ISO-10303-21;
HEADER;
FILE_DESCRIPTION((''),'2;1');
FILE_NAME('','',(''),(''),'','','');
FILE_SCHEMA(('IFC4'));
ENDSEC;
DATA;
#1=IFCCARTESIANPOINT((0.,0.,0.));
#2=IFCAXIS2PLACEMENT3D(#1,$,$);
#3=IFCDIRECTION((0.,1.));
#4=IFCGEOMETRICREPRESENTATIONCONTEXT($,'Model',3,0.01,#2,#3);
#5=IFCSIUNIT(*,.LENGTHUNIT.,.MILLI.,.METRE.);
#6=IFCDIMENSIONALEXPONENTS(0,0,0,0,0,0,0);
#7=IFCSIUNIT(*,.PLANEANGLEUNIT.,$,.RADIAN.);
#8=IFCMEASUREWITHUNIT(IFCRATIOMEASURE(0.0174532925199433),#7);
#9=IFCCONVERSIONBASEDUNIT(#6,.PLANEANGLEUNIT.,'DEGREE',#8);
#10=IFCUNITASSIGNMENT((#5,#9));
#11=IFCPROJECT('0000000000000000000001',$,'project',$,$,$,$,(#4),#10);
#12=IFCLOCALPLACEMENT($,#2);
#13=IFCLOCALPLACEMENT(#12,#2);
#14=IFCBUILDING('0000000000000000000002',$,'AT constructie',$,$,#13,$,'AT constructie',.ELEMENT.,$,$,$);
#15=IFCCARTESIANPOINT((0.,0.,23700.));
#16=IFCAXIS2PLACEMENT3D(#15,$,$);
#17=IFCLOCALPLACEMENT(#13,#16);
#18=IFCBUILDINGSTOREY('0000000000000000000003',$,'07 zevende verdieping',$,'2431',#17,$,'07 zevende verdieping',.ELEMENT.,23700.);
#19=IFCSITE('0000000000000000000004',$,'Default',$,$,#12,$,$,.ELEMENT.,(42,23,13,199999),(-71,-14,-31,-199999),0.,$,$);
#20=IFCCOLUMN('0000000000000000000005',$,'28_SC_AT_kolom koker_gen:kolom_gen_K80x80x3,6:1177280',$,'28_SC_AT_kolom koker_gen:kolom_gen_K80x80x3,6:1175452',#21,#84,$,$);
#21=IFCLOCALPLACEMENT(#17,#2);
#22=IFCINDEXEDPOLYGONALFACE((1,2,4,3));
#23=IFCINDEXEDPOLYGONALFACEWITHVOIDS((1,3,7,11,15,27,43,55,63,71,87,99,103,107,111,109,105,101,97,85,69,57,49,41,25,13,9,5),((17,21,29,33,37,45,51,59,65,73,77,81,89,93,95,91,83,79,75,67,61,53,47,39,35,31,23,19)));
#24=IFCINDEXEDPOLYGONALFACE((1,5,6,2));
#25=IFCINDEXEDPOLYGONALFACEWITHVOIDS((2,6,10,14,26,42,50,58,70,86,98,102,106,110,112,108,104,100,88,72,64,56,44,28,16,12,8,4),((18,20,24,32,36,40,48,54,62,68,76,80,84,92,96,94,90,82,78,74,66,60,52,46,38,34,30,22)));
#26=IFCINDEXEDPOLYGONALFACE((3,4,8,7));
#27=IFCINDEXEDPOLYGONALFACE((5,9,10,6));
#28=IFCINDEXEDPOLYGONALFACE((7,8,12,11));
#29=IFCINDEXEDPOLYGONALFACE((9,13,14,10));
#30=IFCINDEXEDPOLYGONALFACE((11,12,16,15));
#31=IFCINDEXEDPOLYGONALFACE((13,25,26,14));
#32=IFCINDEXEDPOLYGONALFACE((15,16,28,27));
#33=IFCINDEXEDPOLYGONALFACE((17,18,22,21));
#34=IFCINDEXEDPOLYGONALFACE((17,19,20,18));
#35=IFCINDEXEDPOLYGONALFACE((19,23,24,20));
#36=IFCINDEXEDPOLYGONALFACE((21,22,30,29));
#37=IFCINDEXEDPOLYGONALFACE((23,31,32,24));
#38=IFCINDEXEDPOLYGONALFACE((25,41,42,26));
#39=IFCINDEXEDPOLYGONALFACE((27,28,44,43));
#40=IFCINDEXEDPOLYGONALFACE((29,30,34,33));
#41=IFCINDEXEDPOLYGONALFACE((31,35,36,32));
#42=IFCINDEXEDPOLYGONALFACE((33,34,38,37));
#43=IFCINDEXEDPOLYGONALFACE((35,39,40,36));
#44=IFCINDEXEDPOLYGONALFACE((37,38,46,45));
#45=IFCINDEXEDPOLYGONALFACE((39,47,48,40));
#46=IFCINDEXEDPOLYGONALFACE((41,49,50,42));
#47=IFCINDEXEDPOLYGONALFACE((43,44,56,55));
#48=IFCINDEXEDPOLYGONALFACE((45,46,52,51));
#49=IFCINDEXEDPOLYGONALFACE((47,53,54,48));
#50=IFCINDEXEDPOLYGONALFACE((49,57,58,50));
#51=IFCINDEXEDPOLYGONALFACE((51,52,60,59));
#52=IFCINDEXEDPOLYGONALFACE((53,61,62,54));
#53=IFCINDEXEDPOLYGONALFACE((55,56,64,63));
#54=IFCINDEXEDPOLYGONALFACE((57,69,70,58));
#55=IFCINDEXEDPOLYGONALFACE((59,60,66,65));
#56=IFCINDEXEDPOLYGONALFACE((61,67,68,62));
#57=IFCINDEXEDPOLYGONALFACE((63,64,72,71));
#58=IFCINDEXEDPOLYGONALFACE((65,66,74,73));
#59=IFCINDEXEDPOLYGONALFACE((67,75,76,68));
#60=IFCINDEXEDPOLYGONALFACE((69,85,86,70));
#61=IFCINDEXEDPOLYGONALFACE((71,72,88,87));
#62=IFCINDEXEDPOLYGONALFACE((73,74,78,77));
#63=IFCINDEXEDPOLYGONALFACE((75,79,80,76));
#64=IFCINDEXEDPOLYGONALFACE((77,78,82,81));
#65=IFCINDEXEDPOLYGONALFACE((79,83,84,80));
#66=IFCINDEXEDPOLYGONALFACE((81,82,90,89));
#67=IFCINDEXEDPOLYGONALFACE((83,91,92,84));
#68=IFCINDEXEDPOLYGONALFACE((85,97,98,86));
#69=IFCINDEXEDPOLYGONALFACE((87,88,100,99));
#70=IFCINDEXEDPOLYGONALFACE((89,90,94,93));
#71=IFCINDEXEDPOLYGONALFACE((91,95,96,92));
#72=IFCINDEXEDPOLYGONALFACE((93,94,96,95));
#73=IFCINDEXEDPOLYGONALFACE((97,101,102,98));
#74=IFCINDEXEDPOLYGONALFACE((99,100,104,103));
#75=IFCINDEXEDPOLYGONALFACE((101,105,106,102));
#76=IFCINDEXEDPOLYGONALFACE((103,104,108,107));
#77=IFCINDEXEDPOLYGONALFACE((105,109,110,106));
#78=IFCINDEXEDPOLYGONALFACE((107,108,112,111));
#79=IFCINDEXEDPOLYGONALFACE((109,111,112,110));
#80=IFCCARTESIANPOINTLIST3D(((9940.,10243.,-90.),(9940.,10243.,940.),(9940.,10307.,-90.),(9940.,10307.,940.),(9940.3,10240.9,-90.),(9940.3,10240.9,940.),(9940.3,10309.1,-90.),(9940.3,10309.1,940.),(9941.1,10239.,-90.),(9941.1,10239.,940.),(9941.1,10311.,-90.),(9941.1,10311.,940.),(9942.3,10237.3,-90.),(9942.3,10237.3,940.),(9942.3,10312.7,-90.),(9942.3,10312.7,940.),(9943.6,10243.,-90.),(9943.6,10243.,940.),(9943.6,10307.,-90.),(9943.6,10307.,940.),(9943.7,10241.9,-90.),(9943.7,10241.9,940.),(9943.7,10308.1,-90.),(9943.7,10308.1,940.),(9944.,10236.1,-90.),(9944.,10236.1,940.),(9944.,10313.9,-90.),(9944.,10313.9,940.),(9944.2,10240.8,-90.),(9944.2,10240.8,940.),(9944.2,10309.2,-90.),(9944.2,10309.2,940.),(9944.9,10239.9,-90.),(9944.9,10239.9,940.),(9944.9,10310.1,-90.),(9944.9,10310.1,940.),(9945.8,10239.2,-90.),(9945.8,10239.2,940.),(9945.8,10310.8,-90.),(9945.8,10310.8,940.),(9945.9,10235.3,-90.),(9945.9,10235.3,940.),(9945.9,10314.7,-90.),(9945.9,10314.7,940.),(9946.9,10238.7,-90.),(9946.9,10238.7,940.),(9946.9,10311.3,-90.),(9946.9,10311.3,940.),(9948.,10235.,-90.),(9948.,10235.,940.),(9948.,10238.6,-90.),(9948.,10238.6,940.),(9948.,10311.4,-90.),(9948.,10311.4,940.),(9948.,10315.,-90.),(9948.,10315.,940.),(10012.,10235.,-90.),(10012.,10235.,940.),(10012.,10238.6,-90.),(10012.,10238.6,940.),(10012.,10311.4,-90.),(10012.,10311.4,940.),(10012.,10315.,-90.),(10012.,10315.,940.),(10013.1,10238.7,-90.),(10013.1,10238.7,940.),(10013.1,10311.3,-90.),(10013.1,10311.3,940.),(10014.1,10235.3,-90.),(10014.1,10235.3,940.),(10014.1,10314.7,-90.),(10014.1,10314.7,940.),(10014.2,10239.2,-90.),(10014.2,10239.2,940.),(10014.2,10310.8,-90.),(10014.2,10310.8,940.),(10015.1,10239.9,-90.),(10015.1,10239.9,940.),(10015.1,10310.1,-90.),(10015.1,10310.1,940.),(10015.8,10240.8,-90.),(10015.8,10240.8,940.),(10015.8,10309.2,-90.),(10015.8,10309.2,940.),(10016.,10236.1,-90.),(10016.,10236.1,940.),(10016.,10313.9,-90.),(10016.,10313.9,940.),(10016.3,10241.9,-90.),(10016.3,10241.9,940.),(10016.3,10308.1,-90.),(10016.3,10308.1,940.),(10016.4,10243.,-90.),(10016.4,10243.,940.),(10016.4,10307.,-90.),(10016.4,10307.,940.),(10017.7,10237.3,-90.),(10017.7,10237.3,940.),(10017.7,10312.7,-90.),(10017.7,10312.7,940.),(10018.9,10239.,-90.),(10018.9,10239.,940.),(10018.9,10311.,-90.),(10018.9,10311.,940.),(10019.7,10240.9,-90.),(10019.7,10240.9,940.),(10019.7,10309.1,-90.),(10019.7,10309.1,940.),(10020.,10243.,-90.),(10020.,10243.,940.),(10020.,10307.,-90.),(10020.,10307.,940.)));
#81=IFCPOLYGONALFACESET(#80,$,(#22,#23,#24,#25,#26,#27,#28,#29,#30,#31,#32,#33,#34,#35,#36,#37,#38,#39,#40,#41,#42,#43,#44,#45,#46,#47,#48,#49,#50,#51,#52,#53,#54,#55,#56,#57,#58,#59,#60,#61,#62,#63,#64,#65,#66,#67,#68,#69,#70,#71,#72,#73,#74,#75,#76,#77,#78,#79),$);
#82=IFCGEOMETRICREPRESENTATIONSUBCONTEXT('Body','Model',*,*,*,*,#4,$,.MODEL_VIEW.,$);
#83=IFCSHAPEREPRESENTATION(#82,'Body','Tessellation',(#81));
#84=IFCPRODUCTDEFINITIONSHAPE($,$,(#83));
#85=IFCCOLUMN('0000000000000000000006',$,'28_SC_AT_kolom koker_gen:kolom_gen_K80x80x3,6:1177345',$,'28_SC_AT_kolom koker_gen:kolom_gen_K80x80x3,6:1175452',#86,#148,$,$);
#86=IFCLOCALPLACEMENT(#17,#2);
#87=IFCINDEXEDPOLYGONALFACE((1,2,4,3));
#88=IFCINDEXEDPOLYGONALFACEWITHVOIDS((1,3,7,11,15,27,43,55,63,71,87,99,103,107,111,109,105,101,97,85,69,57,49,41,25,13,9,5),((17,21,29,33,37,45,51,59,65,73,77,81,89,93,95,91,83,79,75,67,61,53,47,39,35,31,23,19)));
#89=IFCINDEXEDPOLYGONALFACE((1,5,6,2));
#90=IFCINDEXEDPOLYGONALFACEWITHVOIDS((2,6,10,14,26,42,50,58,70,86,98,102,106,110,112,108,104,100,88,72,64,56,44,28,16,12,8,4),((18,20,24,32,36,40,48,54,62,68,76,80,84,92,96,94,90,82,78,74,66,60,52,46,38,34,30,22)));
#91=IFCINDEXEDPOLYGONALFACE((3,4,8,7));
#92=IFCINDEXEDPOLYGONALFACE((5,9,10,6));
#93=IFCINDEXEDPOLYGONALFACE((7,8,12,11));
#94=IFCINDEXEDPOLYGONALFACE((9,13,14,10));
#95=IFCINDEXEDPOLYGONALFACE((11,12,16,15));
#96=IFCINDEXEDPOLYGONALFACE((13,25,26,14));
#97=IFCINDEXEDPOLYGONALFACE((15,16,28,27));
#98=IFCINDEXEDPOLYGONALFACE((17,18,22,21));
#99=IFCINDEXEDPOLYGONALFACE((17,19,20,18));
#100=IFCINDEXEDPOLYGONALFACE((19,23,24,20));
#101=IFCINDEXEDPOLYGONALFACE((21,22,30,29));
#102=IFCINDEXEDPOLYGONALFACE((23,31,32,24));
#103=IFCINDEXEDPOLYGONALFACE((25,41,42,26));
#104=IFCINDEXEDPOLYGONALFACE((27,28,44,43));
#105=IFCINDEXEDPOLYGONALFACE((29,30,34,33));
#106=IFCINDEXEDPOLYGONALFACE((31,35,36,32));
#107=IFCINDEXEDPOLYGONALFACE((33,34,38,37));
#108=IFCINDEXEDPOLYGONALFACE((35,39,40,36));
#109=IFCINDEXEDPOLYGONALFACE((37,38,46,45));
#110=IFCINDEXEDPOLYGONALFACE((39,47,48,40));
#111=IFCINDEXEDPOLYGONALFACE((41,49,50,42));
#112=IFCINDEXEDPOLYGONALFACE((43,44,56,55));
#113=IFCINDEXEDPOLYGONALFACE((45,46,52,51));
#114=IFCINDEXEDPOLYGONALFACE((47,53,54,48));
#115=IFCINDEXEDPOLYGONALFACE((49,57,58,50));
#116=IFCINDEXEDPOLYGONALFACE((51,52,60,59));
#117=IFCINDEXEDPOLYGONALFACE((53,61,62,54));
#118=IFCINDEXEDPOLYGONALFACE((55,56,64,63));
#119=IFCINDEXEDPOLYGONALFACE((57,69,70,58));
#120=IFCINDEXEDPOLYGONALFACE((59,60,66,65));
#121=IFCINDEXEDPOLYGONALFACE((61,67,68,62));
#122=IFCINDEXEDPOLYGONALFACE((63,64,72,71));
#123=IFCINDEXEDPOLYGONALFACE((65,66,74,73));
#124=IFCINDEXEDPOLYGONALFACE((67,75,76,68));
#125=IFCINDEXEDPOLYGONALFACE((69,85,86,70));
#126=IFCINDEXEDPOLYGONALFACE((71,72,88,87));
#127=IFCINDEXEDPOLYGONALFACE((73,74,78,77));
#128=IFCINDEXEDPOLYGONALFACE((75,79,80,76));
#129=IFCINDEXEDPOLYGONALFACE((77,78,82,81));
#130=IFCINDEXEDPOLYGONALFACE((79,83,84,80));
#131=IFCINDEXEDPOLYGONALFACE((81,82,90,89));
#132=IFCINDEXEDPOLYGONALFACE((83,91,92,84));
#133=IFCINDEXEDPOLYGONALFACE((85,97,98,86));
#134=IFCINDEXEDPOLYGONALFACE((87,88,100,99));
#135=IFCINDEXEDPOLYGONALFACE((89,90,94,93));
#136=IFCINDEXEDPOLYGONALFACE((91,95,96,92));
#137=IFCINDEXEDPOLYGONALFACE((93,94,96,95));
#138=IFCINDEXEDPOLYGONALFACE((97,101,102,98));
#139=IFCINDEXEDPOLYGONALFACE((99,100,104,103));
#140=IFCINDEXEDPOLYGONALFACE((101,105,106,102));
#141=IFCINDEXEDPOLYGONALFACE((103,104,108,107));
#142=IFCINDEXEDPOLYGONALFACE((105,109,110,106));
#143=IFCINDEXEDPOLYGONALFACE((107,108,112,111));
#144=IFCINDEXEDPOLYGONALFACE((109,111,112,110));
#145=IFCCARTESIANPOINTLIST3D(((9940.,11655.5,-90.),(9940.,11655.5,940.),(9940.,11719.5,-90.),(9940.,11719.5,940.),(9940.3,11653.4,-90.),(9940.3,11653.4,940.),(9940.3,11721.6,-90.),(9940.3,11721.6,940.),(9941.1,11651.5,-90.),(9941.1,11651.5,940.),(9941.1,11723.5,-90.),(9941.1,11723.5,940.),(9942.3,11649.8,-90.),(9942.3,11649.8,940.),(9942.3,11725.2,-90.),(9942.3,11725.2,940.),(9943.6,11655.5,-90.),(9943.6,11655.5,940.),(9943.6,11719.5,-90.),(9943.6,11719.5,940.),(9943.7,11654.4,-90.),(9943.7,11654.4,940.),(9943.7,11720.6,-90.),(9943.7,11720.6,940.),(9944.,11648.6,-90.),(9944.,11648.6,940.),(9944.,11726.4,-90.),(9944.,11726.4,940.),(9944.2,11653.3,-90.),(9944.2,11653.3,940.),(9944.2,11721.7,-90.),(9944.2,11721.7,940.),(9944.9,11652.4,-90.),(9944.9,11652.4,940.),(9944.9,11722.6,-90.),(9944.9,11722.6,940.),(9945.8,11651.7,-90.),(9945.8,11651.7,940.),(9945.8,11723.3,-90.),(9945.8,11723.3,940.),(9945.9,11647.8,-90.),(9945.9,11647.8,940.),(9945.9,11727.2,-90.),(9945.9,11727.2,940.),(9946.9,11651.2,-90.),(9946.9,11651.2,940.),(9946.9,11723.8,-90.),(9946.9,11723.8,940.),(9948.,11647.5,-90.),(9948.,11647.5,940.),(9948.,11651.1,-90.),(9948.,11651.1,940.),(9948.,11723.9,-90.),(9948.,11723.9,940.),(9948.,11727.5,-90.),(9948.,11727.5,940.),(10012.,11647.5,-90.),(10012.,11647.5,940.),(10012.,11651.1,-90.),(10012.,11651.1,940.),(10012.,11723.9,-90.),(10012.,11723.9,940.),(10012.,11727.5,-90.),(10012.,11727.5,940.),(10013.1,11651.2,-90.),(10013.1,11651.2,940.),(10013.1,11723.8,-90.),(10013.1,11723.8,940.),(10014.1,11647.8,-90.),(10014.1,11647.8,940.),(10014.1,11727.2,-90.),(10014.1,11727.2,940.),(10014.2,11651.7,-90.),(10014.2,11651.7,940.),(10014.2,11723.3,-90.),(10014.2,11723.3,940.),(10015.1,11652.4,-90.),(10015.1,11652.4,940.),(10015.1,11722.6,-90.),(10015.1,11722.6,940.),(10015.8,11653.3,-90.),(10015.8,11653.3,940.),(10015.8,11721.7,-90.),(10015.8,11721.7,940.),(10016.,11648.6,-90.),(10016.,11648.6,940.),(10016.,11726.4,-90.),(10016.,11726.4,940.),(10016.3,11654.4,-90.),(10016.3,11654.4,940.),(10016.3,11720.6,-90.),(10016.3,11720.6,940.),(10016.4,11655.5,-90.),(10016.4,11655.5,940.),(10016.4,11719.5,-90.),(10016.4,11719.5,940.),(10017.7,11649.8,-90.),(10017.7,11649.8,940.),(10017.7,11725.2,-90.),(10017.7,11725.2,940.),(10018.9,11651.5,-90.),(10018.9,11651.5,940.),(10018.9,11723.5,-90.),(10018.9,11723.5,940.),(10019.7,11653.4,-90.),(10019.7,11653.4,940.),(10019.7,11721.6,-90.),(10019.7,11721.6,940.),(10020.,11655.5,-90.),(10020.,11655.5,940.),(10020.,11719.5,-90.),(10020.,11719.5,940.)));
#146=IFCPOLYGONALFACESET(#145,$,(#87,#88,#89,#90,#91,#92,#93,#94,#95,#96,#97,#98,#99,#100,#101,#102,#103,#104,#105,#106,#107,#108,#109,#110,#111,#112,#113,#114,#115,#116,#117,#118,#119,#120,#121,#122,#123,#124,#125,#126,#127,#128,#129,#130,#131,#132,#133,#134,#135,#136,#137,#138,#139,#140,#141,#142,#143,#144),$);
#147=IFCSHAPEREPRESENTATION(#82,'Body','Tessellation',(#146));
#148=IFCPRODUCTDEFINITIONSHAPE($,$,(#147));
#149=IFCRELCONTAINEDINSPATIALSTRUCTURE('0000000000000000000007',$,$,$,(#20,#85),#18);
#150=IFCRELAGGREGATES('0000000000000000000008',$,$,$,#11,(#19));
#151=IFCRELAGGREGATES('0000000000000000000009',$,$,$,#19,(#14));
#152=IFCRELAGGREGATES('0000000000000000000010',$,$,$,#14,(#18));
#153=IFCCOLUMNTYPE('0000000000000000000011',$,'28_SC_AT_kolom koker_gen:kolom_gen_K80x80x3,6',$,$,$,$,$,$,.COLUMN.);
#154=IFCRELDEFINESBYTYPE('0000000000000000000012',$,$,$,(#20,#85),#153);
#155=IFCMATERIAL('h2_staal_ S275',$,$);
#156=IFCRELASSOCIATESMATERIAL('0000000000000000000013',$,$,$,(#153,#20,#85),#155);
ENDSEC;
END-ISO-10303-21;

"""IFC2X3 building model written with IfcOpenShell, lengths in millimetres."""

from ifc_helpers import new_model, entity, si_unit, converted_unit, direction, frame, frame_2d, origin, place, context, subcontext, project, spatial, polyline, circle_curve, parameter, trimmed, segment, composite_curve, outline, extrude, source, transform, mapped, material, type_object, type_shapes, element, save


model = new_model("IFC2X3")

# Units and contexts
model_context = context("Model", 3, precision=0.01, world=origin(), true_north=direction((0.0, 1.0)))
body_context = subcontext(model_context, "Body", "Model", "MODEL_VIEW")
ifc_project = project(units=[si_unit("LENGTHUNIT", "METRE", prefix="MILLI"), converted_unit("PLANEANGLEUNIT", "DEGREE", entity("IfcRatioMeasure", 0.0174532925199433), si_unit("PLANEANGLEUNIT", "RADIAN"), dimensions=[0, 0, 0, 0, 0, 0, 0])], contexts=[model_context])

# Site, building, storey
site_placement = place(None, origin())
site = spatial("IfcSite", under=ifc_project, at=site_placement, Name="Default", CompositionType="ELEMENT", RefLatitude=(42, 23, 13, 199999), RefLongitude=(-71, -14, -31, -199999), RefElevation=0.0)
building_placement = place(site_placement, origin())
building = spatial("IfcBuilding", under=site, at=building_placement, Name="AT constructie", LongName="AT constructie", CompositionType="ELEMENT")
storey_placement = place(building_placement, frame((0.0, 0.0, 23700.0)))
storey = spatial("IfcBuildingStorey", under=building, at=storey_placement, Name="07 zevende verdieping", ObjectType="2431", LongName="07 zevende verdieping", CompositionType="ELEMENT", Elevation=23700.0)

# Columns
ifc_material = material(Name="h2_staal_ S275")
column_type_1 = type_object("IfcColumnType", Name="28_SC_AT_kolom koker_gen:kolom_gen_K80x80x3,6", PredefinedType="COLUMN", material=ifc_material)
shared_shape_1 = source(origin(), body_context, "Body", "SweptSolid", [
    extrude(outline(composite_curve([segment(trimmed(circle_curve(frame_2d((32.0, 32.0), x_axis=(1.0, 0.0)), 8.0), [parameter(360.0)], [parameter(90.0)], True, "PARAMETER"), True, "CONTINUOUS"), segment(polyline([(32.0, 40.0), (-32.0, 40.0)]), True, "CONTINUOUS"), segment(trimmed(circle_curve(frame_2d((-32.0, 32.0), x_axis=(1.0, 0.0)), 8.0), [parameter(90.0)], [parameter(180.0)], True, "PARAMETER"), True, "CONTINUOUS"), segment(polyline([(-40.0, 32.0), (-40.0, -32.0)]), True, "CONTINUOUS"), segment(trimmed(circle_curve(frame_2d((-32.0, -32.0), x_axis=(1.0, 0.0)), 8.0), [parameter(180.0)], [parameter(270.0)], True, "PARAMETER"), True, "CONTINUOUS"), segment(polyline([(-32.0, -40.0), (32.0, -40.0)]), True, "CONTINUOUS"), segment(trimmed(circle_curve(frame_2d((32.0, -32.0), x_axis=(1.0, 0.0)), 8.0), [parameter(270.0)], [parameter(0.0)], True, "PARAMETER"), True, "CONTINUOUS"), segment(polyline([(40.0, -32.0), (40.0, 32.0)]), True, "CONTINUOUS")], self_intersect=False), holes=[composite_curve([segment(polyline([(-32.0, 36.4), (32.0, 36.4)]), True, "CONTINUOUS"), segment(trimmed(circle_curve(frame_2d((32.0, 32.0), x_axis=(1.0, 0.0)), 4.4), [parameter(360.0)], [parameter(90.0)], True, "PARAMETER"), False, "CONTINUOUS"), segment(polyline([(36.4, 32.0), (36.4, -32.0)]), True, "CONTINUOUS"), segment(trimmed(circle_curve(frame_2d((32.0, -32.0), x_axis=(1.0, 0.0)), 4.4), [parameter(270.0)], [parameter(360.0)], True, "PARAMETER"), False, "CONTINUOUS"), segment(polyline([(32.0, -36.4), (-32.0, -36.4)]), True, "CONTINUOUS"), segment(trimmed(circle_curve(frame_2d((-32.0, -32.0), x_axis=(1.0, 0.0)), 4.4), [parameter(180.0)], [parameter(270.0)], True, "PARAMETER"), False, "CONTINUOUS"), segment(polyline([(-36.4, -32.0), (-36.4, 32.0)]), True, "CONTINUOUS"), segment(trimmed(circle_curve(frame_2d((-32.0, 32.0), x_axis=(1.0, 0.0)), 4.4), [parameter(90.0)], [parameter(180.0)], True, "PARAMETER"), False, "CONTINUOUS")], self_intersect=False)]), frame((0.0, 0.0, 23610.0), z_axis=(0.0, 0.0, 1.0), x_axis=(-1.0, 0.0, 0.0)), (0.0, 0.0, 1.0), 1030.0),
])
type_shapes(column_type_1, [shared_shape_1])
for number, where, name in (
    (1, (9980.0, 10275.0, -23700.0), "28_SC_AT_kolom koker_gen:kolom_gen_K80x80x3,6:1177280"),
    (2, (9980.0, 11687.5, -23700.0), "28_SC_AT_kolom koker_gen:kolom_gen_K80x80x3,6:1177345"),
):
    element("IfcColumn", number, at=place(storey_placement, frame(where)), inside=storey, type_object=column_type_1, material=ifc_material, Name=name, ObjectType="28_SC_AT_kolom koker_gen:kolom_gen_K80x80x3,6:1175452", context=body_context, shape_type="MappedRepresentation", body=[
        mapped(shared_shape_1, transform((0.0, 0.0, 0.0), scale=1.0)),
    ])

save(model, "model.ifc")
